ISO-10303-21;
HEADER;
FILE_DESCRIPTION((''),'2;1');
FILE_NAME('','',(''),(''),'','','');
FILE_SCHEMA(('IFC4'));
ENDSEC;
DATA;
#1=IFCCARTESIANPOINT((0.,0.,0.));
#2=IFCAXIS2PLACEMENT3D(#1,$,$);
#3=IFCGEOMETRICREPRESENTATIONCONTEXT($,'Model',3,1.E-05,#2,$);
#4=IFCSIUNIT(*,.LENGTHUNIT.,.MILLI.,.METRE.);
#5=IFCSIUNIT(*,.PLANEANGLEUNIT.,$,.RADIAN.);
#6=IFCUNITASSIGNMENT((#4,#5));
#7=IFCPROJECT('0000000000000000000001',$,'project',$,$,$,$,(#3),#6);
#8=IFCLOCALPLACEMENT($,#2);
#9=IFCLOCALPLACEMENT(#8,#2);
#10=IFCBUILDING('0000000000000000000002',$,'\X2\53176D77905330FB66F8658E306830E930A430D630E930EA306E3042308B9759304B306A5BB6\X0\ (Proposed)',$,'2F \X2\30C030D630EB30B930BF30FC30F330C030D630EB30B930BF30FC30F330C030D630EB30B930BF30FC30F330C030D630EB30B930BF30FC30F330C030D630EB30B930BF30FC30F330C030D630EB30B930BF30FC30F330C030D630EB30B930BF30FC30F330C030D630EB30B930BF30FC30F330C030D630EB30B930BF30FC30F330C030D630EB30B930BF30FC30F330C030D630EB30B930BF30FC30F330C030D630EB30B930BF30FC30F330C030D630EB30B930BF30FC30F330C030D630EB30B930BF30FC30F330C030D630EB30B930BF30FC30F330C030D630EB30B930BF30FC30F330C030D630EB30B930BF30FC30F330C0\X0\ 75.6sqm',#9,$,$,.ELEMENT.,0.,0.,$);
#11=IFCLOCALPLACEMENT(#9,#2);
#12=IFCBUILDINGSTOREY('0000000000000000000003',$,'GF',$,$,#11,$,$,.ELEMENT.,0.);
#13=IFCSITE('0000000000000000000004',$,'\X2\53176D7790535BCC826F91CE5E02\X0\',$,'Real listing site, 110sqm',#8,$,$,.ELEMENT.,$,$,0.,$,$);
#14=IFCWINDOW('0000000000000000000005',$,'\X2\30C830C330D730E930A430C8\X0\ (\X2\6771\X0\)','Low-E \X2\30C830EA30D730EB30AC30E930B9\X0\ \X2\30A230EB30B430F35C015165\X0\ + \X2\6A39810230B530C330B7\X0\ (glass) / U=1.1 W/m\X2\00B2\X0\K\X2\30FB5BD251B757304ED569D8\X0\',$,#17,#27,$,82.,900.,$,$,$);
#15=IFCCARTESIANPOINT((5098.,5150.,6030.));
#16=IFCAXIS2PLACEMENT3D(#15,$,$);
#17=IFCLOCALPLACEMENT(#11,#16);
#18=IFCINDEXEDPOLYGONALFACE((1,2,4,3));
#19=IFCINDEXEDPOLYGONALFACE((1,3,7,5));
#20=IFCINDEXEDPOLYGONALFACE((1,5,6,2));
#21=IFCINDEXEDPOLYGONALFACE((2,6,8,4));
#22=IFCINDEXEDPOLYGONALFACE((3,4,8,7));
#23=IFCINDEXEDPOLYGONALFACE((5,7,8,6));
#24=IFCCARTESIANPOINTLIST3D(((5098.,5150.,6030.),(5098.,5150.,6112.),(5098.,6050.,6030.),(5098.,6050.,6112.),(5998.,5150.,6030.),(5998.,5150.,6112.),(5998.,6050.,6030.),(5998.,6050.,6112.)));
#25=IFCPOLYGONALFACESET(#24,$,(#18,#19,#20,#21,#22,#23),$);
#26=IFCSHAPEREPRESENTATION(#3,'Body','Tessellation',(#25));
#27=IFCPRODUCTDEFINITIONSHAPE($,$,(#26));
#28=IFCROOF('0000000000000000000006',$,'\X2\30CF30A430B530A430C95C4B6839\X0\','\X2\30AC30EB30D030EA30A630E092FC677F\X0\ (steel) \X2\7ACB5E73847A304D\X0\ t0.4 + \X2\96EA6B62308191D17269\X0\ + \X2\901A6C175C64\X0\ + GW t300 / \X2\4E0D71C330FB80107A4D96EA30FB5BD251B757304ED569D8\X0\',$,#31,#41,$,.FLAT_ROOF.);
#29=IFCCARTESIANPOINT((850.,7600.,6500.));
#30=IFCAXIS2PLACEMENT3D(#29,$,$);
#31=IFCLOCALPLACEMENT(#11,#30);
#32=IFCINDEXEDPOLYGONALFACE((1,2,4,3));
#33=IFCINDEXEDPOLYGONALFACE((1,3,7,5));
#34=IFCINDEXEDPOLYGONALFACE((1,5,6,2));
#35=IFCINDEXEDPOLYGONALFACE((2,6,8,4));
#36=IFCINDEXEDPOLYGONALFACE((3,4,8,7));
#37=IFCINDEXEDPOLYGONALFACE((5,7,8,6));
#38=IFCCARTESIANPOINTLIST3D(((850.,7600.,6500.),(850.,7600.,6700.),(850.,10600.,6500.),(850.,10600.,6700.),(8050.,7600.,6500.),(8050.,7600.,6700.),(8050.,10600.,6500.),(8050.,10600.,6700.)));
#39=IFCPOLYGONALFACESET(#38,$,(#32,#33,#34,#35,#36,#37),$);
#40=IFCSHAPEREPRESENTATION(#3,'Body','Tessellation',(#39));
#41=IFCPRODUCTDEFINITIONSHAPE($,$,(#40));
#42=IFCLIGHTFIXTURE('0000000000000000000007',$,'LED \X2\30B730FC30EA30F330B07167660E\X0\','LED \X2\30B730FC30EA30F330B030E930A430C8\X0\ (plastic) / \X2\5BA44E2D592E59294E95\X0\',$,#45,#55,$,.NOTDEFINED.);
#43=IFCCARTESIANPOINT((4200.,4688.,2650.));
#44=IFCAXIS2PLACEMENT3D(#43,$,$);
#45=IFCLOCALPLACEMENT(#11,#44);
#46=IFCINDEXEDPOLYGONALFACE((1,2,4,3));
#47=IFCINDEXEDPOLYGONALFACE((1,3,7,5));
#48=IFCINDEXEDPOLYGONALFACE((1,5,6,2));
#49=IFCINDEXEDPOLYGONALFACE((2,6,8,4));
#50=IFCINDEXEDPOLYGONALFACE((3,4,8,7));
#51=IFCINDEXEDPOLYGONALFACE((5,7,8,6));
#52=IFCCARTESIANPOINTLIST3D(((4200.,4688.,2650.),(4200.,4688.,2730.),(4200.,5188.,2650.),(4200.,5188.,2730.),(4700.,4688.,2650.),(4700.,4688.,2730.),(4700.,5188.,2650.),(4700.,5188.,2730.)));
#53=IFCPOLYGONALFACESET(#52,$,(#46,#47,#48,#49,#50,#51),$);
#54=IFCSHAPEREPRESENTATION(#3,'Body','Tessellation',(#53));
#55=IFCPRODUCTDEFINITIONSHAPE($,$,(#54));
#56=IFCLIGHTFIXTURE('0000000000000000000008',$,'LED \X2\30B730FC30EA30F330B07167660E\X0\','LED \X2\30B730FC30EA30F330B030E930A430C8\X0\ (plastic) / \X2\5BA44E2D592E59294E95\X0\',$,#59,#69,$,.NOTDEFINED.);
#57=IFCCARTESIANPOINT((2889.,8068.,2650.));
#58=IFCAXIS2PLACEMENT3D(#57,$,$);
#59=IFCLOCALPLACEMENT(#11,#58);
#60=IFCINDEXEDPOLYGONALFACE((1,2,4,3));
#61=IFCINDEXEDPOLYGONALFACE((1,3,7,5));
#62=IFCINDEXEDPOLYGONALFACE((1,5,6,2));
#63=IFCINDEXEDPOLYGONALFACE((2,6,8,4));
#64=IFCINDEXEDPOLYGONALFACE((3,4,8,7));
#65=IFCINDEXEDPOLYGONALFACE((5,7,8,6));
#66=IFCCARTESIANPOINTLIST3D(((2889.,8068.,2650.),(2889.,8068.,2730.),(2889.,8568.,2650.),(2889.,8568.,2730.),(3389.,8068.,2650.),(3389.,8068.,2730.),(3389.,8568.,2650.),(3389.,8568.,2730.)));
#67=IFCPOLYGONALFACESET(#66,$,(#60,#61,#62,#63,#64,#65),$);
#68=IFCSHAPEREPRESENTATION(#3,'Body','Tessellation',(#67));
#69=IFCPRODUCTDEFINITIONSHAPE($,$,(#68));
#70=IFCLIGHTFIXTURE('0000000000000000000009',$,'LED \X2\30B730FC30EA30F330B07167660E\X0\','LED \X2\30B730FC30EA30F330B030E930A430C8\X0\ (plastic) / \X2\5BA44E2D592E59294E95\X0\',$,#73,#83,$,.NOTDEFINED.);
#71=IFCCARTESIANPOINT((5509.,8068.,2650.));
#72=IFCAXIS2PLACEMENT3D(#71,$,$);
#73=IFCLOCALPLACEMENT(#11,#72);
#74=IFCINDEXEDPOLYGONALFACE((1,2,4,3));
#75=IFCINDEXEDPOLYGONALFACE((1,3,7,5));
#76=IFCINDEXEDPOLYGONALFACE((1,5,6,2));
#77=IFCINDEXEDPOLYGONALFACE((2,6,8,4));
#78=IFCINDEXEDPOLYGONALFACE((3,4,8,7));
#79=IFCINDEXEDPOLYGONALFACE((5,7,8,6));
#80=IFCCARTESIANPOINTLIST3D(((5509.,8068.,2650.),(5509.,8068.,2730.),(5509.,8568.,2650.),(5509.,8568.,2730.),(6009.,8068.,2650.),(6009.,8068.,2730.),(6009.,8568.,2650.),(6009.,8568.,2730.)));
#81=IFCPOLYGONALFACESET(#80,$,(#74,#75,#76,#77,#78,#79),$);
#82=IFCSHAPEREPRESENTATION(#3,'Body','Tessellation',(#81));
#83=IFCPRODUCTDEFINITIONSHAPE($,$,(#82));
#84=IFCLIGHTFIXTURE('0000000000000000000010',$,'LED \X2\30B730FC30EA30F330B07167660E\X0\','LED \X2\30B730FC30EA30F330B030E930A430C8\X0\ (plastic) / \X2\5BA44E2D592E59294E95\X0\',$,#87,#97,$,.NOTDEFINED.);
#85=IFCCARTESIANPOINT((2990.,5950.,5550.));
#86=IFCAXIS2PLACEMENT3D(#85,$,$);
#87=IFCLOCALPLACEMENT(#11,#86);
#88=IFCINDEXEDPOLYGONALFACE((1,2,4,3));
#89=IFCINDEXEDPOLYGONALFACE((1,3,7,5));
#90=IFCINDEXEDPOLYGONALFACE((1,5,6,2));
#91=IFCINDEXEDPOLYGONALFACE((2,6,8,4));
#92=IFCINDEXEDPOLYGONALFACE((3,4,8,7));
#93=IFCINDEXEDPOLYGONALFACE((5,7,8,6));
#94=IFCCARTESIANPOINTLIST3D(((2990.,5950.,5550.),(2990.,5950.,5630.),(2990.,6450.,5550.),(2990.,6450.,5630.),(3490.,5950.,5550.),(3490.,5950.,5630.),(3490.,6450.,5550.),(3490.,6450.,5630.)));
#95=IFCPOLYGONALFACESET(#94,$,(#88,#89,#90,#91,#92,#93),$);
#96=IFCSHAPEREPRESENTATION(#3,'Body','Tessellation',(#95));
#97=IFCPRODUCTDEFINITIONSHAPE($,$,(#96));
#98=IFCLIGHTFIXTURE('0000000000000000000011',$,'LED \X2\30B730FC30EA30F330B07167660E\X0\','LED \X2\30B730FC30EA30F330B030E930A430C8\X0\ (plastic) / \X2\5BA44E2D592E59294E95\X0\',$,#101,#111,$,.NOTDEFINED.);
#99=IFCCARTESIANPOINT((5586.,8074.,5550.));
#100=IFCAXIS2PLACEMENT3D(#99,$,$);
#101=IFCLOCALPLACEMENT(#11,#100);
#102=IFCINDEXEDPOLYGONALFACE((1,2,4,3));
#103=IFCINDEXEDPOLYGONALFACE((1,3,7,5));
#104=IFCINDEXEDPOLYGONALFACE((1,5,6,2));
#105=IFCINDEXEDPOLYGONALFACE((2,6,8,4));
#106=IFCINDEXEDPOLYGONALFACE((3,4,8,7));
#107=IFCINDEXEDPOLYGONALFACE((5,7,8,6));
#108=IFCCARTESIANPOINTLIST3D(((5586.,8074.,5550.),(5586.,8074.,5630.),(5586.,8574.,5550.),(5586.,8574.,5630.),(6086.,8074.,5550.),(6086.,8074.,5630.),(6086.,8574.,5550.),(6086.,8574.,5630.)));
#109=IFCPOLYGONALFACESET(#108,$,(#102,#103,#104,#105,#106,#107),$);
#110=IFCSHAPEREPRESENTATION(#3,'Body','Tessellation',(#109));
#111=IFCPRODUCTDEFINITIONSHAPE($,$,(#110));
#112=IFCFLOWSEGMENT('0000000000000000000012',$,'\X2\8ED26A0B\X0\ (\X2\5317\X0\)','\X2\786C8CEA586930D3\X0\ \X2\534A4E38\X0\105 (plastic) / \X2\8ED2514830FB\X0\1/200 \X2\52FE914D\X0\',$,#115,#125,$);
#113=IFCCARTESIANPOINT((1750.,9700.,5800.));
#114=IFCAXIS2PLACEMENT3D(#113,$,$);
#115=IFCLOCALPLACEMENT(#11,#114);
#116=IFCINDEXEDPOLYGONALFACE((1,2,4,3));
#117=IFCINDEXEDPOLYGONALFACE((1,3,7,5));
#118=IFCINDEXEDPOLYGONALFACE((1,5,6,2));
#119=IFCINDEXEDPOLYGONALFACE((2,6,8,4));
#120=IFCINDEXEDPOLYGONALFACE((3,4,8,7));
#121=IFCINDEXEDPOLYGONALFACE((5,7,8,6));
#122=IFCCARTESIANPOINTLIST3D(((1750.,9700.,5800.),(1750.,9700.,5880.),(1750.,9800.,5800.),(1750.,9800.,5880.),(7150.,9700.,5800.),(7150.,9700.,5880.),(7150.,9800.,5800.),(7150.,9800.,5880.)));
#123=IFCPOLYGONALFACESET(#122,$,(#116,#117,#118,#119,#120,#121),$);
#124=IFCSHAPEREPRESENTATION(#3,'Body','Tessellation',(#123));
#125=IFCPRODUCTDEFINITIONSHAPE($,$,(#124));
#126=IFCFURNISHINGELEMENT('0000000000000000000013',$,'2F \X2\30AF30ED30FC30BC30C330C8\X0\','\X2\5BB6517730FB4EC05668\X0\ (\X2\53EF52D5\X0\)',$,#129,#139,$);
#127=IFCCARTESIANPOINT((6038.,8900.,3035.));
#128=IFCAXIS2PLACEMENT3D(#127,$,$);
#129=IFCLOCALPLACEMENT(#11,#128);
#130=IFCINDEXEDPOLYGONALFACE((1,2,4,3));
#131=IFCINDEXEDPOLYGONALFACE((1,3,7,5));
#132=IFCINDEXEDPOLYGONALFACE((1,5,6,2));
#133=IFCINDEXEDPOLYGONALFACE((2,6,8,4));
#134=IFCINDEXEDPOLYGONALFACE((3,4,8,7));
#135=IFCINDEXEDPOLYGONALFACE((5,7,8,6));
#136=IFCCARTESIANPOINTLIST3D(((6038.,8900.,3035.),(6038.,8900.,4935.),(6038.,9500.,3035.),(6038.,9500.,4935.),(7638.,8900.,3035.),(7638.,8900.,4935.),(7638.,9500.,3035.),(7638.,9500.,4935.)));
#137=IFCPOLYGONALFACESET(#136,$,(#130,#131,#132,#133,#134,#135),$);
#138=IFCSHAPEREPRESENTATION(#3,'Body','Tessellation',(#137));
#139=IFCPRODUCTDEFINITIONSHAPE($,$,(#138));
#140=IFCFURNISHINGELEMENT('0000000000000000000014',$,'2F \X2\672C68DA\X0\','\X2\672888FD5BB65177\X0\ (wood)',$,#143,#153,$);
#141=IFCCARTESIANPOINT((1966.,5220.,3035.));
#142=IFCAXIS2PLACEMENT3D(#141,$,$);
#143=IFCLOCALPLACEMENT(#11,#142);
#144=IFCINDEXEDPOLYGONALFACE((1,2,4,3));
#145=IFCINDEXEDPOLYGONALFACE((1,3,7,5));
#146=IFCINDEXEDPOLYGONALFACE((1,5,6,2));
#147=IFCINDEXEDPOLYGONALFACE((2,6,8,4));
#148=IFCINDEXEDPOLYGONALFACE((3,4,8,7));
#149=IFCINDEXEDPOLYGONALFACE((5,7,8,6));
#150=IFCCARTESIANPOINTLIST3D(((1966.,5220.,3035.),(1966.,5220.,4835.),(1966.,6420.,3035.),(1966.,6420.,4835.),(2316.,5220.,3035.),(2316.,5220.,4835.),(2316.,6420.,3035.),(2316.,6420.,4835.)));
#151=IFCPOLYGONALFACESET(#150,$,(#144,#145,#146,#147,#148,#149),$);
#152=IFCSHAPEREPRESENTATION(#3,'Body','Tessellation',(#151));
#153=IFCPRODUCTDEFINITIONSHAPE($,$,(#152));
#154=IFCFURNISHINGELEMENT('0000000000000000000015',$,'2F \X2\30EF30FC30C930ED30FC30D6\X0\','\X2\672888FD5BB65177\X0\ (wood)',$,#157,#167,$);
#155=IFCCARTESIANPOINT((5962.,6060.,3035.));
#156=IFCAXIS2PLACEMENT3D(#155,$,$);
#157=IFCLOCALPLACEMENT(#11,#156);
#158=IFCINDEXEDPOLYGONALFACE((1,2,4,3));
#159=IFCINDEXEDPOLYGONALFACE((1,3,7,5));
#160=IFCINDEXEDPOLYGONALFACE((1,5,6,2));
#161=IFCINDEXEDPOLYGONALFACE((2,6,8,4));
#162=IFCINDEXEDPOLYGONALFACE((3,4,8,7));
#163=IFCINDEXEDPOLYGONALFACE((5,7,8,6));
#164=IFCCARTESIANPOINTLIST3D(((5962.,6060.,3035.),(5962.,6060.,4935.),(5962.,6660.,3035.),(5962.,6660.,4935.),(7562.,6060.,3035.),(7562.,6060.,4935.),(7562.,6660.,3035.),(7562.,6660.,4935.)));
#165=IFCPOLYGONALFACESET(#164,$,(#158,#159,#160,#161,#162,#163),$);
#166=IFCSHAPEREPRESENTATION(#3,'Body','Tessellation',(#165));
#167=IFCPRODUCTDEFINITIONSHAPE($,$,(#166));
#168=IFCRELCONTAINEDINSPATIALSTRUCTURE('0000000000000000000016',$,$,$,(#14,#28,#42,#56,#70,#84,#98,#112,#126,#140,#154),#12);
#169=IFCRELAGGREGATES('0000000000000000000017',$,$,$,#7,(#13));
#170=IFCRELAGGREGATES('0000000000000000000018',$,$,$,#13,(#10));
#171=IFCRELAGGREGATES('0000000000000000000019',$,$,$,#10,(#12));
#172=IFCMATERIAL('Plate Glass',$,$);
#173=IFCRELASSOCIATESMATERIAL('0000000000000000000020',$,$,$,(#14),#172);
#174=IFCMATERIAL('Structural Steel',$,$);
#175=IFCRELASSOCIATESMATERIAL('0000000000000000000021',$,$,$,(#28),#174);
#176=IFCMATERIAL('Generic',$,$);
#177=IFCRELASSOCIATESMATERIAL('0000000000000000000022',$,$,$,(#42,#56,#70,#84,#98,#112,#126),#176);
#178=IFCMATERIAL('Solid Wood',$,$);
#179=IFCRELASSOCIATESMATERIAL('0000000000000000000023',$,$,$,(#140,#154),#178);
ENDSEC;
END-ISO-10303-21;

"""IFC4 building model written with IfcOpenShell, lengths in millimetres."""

from ifc_helpers import new_model, si_unit, frame, frame_2d, origin, place, context, project, spatial, rectangle, extrude, material, element, save


model = new_model("IFC4")

# Units and contexts
model_context = context("Model", 3, precision=1e-05, world=origin())
ifc_project = project(units=[si_unit("LENGTHUNIT", "METRE", prefix="MILLI"), si_unit("PLANEANGLEUNIT", "RADIAN")], contexts=[model_context])

# Site, building, storey
site_placement = place(None, origin())
site = spatial("IfcSite", under=ifc_project, at=site_placement, Name="北海道富良野市", ObjectType="Real listing site, 110sqm", CompositionType="ELEMENT", RefElevation=0.0)
building_placement = place(site_placement, origin())
building = spatial("IfcBuilding", under=site, at=building_placement, Name="北海道・書斎とライブラリのある静かな家 (Proposed)", ObjectType="2F ダブルスターンダブルスターンダブルスターンダブルスターンダブルスターンダブルスターンダブルスターンダブルスターンダブルスターンダブルスターンダブルスターンダブルスターンダブルスターンダブルスターンダブルスターンダブルスターンダブルスターンダ 75.6sqm", CompositionType="ELEMENT", ElevationOfRefHeight=0.0, ElevationOfTerrain=0.0)
storey_placement = place(building_placement, origin())
storey = spatial("IfcBuildingStorey", under=building, at=storey_placement, Name="GF", CompositionType="ELEMENT", Elevation=0.0)

# Shared definitions
ifc_material_1 = material(Name="Solid Wood")

# Shared definitions
ifc_material_2 = material(Name="Plate Glass")

# Window
window_1_placement = place(storey_placement, frame((5098.0, 5150.0, 6030.0)))
element("IfcWindow", 1, at=window_1_placement, inside=storey, material=ifc_material_2, Name="トップライト (東)", Description="Low-E トリプルガラス アルゴン封入 + 樹脂サッシ (glass) / U=1.1 W/m²K・寒冷地仕様", OverallHeight=82.0, OverallWidth=900.0, context=model_context, shape_type="SweptSolid", body=[
    extrude(rectangle(XDim=900.0, YDim=900.0, at=frame_2d((450.0, 450.0))), frame((5098.0, 5150.0, 6030.0)), (0.0, 0.0, 1.0), 82.0),
])

# Roof
ifc_material_3 = material(Name="Structural Steel")
roof_placement = place(storey_placement, frame((850.0, 7600.0, 6500.0)))
element("IfcRoof", 2, at=roof_placement, inside=storey, material=ifc_material_3, Name="ハイサイド屋根", Description="ガルバリウム鋼板 (steel) 立平葺き t0.4 + 雪止め金物 + 通気層 + GW t300 / 不燃・耐積雪・寒冷地仕様", PredefinedType="FLAT_ROOF", context=model_context, shape_type="SweptSolid", body=[
    extrude(rectangle(XDim=7200.0, YDim=3000.0, at=frame_2d((3600.0, 1500.0))), frame((850.0, 7600.0, 6500.0)), (0.0, 0.0, 1.0), 200.0),
])

# Light fixtures
ifc_material_4 = material(Name="Generic")
light_fixture_1_placement = place(storey_placement, frame((4200.0, 4688.0, 2650.0)))
element("IfcLightFixture", 3, at=light_fixture_1_placement, inside=storey, material=ifc_material_4, Name="LED シーリング照明", Description="LED シーリングライト (plastic) / 室中央天井", PredefinedType="NOTDEFINED", context=model_context, shape_type="SweptSolid", body=[
    extrude(rectangle(XDim=500.0, YDim=500.0, at=frame_2d((250.0, 250.0))), frame((4200.0, 4688.0, 2650.0)), (0.0, 0.0, 1.0), 80.0),
])
light_fixture_2_placement = place(storey_placement, frame((2889.0, 8068.0, 2650.0)))
element("IfcLightFixture", 4, at=light_fixture_2_placement, inside=storey, material=ifc_material_4, Name="LED シーリング照明", Description="LED シーリングライト (plastic) / 室中央天井", PredefinedType="NOTDEFINED", context=model_context, shape_type="SweptSolid", body=[
    extrude(rectangle(XDim=500.0, YDim=500.0, at=frame_2d((250.0, 250.0))), frame((2889.0, 8068.0, 2650.0)), (0.0, 0.0, 1.0), 80.0),
])
light_fixture_3_placement = place(storey_placement, frame((5509.0, 8068.0, 2650.0)))
element("IfcLightFixture", 5, at=light_fixture_3_placement, inside=storey, material=ifc_material_4, Name="LED シーリング照明", Description="LED シーリングライト (plastic) / 室中央天井", PredefinedType="NOTDEFINED", context=model_context, shape_type="SweptSolid", body=[
    extrude(rectangle(XDim=500.0, YDim=500.0, at=frame_2d((250.0, 250.0))), frame((5509.0, 8068.0, 2650.0)), (0.0, 0.0, 1.0), 80.0),
])
light_fixture_4_placement = place(storey_placement, frame((2990.0, 5950.0, 5550.0)))
element("IfcLightFixture", 6, at=light_fixture_4_placement, inside=storey, material=ifc_material_4, Name="LED シーリング照明", Description="LED シーリングライト (plastic) / 室中央天井", PredefinedType="NOTDEFINED", context=model_context, shape_type="SweptSolid", body=[
    extrude(rectangle(XDim=500.0, YDim=500.0, at=frame_2d((250.0, 250.0))), frame((2990.0, 5950.0, 5550.0)), (0.0, 0.0, 1.0), 80.0),
])
light_fixture_5_placement = place(storey_placement, frame((5586.0, 8074.0, 5550.0)))
element("IfcLightFixture", 7, at=light_fixture_5_placement, inside=storey, material=ifc_material_4, Name="LED シーリング照明", Description="LED シーリングライト (plastic) / 室中央天井", PredefinedType="NOTDEFINED", context=model_context, shape_type="SweptSolid", body=[
    extrude(rectangle(XDim=500.0, YDim=500.0, at=frame_2d((250.0, 250.0))), frame((5586.0, 8074.0, 5550.0)), (0.0, 0.0, 1.0), 80.0),
])

# Flow segment
flow_segment_placement = place(storey_placement, frame((1750.0, 9700.0, 5800.0)))
element("IfcFlowSegment", 8, at=flow_segment_placement, inside=storey, material=ifc_material_4, Name="軒樋 (北)", Description="硬質塩ビ 半丸105 (plastic) / 軒先・1/200 勾配", context=model_context, shape_type="SweptSolid", body=[
    extrude(rectangle(XDim=5400.0, YDim=100.0, at=frame_2d((2700.0, 50.0))), frame((1750.0, 9700.0, 5800.0)), (0.0, 0.0, 1.0), 80.0),
])

# Furnishing elements
furnishing_1_placement = place(storey_placement, frame((6038.0, 8900.0, 3035.0)))
element("IfcFurnishingElement", 9, at=furnishing_1_placement, inside=storey, material=ifc_material_4, Name="2F クローゼット", Description="家具・什器 (可動)", context=model_context, shape_type="SweptSolid", body=[
    extrude(rectangle(XDim=1600.0, YDim=600.0, at=frame_2d((800.0, 300.0))), frame((6038.0, 8900.0, 3035.0)), (0.0, 0.0, 1.0), 1900.0),
])
furnishing_2_placement = place(storey_placement, frame((1966.0, 5220.0, 3035.0)))
element("IfcFurnishingElement", 10, at=furnishing_2_placement, inside=storey, material=ifc_material_1, Name="2F 本棚", Description="木製家具 (wood)", context=model_context, shape_type="SweptSolid", body=[
    extrude(rectangle(XDim=350.0, YDim=1200.0, at=frame_2d((175.0, 600.0))), frame((1966.0, 5220.0, 3035.0)), (0.0, 0.0, 1.0), 1800.0),
])
furnishing_3_placement = place(storey_placement, frame((5962.0, 6060.0, 3035.0)))
element("IfcFurnishingElement", 11, at=furnishing_3_placement, inside=storey, material=ifc_material_1, Name="2F ワードローブ", Description="木製家具 (wood)", context=model_context, shape_type="SweptSolid", body=[
    extrude(rectangle(XDim=1600.0, YDim=600.0, at=frame_2d((800.0, 300.0))), frame((5962.0, 6060.0, 3035.0)), (0.0, 0.0, 1.0), 1900.0),
])

save(model, "model.ifc")
